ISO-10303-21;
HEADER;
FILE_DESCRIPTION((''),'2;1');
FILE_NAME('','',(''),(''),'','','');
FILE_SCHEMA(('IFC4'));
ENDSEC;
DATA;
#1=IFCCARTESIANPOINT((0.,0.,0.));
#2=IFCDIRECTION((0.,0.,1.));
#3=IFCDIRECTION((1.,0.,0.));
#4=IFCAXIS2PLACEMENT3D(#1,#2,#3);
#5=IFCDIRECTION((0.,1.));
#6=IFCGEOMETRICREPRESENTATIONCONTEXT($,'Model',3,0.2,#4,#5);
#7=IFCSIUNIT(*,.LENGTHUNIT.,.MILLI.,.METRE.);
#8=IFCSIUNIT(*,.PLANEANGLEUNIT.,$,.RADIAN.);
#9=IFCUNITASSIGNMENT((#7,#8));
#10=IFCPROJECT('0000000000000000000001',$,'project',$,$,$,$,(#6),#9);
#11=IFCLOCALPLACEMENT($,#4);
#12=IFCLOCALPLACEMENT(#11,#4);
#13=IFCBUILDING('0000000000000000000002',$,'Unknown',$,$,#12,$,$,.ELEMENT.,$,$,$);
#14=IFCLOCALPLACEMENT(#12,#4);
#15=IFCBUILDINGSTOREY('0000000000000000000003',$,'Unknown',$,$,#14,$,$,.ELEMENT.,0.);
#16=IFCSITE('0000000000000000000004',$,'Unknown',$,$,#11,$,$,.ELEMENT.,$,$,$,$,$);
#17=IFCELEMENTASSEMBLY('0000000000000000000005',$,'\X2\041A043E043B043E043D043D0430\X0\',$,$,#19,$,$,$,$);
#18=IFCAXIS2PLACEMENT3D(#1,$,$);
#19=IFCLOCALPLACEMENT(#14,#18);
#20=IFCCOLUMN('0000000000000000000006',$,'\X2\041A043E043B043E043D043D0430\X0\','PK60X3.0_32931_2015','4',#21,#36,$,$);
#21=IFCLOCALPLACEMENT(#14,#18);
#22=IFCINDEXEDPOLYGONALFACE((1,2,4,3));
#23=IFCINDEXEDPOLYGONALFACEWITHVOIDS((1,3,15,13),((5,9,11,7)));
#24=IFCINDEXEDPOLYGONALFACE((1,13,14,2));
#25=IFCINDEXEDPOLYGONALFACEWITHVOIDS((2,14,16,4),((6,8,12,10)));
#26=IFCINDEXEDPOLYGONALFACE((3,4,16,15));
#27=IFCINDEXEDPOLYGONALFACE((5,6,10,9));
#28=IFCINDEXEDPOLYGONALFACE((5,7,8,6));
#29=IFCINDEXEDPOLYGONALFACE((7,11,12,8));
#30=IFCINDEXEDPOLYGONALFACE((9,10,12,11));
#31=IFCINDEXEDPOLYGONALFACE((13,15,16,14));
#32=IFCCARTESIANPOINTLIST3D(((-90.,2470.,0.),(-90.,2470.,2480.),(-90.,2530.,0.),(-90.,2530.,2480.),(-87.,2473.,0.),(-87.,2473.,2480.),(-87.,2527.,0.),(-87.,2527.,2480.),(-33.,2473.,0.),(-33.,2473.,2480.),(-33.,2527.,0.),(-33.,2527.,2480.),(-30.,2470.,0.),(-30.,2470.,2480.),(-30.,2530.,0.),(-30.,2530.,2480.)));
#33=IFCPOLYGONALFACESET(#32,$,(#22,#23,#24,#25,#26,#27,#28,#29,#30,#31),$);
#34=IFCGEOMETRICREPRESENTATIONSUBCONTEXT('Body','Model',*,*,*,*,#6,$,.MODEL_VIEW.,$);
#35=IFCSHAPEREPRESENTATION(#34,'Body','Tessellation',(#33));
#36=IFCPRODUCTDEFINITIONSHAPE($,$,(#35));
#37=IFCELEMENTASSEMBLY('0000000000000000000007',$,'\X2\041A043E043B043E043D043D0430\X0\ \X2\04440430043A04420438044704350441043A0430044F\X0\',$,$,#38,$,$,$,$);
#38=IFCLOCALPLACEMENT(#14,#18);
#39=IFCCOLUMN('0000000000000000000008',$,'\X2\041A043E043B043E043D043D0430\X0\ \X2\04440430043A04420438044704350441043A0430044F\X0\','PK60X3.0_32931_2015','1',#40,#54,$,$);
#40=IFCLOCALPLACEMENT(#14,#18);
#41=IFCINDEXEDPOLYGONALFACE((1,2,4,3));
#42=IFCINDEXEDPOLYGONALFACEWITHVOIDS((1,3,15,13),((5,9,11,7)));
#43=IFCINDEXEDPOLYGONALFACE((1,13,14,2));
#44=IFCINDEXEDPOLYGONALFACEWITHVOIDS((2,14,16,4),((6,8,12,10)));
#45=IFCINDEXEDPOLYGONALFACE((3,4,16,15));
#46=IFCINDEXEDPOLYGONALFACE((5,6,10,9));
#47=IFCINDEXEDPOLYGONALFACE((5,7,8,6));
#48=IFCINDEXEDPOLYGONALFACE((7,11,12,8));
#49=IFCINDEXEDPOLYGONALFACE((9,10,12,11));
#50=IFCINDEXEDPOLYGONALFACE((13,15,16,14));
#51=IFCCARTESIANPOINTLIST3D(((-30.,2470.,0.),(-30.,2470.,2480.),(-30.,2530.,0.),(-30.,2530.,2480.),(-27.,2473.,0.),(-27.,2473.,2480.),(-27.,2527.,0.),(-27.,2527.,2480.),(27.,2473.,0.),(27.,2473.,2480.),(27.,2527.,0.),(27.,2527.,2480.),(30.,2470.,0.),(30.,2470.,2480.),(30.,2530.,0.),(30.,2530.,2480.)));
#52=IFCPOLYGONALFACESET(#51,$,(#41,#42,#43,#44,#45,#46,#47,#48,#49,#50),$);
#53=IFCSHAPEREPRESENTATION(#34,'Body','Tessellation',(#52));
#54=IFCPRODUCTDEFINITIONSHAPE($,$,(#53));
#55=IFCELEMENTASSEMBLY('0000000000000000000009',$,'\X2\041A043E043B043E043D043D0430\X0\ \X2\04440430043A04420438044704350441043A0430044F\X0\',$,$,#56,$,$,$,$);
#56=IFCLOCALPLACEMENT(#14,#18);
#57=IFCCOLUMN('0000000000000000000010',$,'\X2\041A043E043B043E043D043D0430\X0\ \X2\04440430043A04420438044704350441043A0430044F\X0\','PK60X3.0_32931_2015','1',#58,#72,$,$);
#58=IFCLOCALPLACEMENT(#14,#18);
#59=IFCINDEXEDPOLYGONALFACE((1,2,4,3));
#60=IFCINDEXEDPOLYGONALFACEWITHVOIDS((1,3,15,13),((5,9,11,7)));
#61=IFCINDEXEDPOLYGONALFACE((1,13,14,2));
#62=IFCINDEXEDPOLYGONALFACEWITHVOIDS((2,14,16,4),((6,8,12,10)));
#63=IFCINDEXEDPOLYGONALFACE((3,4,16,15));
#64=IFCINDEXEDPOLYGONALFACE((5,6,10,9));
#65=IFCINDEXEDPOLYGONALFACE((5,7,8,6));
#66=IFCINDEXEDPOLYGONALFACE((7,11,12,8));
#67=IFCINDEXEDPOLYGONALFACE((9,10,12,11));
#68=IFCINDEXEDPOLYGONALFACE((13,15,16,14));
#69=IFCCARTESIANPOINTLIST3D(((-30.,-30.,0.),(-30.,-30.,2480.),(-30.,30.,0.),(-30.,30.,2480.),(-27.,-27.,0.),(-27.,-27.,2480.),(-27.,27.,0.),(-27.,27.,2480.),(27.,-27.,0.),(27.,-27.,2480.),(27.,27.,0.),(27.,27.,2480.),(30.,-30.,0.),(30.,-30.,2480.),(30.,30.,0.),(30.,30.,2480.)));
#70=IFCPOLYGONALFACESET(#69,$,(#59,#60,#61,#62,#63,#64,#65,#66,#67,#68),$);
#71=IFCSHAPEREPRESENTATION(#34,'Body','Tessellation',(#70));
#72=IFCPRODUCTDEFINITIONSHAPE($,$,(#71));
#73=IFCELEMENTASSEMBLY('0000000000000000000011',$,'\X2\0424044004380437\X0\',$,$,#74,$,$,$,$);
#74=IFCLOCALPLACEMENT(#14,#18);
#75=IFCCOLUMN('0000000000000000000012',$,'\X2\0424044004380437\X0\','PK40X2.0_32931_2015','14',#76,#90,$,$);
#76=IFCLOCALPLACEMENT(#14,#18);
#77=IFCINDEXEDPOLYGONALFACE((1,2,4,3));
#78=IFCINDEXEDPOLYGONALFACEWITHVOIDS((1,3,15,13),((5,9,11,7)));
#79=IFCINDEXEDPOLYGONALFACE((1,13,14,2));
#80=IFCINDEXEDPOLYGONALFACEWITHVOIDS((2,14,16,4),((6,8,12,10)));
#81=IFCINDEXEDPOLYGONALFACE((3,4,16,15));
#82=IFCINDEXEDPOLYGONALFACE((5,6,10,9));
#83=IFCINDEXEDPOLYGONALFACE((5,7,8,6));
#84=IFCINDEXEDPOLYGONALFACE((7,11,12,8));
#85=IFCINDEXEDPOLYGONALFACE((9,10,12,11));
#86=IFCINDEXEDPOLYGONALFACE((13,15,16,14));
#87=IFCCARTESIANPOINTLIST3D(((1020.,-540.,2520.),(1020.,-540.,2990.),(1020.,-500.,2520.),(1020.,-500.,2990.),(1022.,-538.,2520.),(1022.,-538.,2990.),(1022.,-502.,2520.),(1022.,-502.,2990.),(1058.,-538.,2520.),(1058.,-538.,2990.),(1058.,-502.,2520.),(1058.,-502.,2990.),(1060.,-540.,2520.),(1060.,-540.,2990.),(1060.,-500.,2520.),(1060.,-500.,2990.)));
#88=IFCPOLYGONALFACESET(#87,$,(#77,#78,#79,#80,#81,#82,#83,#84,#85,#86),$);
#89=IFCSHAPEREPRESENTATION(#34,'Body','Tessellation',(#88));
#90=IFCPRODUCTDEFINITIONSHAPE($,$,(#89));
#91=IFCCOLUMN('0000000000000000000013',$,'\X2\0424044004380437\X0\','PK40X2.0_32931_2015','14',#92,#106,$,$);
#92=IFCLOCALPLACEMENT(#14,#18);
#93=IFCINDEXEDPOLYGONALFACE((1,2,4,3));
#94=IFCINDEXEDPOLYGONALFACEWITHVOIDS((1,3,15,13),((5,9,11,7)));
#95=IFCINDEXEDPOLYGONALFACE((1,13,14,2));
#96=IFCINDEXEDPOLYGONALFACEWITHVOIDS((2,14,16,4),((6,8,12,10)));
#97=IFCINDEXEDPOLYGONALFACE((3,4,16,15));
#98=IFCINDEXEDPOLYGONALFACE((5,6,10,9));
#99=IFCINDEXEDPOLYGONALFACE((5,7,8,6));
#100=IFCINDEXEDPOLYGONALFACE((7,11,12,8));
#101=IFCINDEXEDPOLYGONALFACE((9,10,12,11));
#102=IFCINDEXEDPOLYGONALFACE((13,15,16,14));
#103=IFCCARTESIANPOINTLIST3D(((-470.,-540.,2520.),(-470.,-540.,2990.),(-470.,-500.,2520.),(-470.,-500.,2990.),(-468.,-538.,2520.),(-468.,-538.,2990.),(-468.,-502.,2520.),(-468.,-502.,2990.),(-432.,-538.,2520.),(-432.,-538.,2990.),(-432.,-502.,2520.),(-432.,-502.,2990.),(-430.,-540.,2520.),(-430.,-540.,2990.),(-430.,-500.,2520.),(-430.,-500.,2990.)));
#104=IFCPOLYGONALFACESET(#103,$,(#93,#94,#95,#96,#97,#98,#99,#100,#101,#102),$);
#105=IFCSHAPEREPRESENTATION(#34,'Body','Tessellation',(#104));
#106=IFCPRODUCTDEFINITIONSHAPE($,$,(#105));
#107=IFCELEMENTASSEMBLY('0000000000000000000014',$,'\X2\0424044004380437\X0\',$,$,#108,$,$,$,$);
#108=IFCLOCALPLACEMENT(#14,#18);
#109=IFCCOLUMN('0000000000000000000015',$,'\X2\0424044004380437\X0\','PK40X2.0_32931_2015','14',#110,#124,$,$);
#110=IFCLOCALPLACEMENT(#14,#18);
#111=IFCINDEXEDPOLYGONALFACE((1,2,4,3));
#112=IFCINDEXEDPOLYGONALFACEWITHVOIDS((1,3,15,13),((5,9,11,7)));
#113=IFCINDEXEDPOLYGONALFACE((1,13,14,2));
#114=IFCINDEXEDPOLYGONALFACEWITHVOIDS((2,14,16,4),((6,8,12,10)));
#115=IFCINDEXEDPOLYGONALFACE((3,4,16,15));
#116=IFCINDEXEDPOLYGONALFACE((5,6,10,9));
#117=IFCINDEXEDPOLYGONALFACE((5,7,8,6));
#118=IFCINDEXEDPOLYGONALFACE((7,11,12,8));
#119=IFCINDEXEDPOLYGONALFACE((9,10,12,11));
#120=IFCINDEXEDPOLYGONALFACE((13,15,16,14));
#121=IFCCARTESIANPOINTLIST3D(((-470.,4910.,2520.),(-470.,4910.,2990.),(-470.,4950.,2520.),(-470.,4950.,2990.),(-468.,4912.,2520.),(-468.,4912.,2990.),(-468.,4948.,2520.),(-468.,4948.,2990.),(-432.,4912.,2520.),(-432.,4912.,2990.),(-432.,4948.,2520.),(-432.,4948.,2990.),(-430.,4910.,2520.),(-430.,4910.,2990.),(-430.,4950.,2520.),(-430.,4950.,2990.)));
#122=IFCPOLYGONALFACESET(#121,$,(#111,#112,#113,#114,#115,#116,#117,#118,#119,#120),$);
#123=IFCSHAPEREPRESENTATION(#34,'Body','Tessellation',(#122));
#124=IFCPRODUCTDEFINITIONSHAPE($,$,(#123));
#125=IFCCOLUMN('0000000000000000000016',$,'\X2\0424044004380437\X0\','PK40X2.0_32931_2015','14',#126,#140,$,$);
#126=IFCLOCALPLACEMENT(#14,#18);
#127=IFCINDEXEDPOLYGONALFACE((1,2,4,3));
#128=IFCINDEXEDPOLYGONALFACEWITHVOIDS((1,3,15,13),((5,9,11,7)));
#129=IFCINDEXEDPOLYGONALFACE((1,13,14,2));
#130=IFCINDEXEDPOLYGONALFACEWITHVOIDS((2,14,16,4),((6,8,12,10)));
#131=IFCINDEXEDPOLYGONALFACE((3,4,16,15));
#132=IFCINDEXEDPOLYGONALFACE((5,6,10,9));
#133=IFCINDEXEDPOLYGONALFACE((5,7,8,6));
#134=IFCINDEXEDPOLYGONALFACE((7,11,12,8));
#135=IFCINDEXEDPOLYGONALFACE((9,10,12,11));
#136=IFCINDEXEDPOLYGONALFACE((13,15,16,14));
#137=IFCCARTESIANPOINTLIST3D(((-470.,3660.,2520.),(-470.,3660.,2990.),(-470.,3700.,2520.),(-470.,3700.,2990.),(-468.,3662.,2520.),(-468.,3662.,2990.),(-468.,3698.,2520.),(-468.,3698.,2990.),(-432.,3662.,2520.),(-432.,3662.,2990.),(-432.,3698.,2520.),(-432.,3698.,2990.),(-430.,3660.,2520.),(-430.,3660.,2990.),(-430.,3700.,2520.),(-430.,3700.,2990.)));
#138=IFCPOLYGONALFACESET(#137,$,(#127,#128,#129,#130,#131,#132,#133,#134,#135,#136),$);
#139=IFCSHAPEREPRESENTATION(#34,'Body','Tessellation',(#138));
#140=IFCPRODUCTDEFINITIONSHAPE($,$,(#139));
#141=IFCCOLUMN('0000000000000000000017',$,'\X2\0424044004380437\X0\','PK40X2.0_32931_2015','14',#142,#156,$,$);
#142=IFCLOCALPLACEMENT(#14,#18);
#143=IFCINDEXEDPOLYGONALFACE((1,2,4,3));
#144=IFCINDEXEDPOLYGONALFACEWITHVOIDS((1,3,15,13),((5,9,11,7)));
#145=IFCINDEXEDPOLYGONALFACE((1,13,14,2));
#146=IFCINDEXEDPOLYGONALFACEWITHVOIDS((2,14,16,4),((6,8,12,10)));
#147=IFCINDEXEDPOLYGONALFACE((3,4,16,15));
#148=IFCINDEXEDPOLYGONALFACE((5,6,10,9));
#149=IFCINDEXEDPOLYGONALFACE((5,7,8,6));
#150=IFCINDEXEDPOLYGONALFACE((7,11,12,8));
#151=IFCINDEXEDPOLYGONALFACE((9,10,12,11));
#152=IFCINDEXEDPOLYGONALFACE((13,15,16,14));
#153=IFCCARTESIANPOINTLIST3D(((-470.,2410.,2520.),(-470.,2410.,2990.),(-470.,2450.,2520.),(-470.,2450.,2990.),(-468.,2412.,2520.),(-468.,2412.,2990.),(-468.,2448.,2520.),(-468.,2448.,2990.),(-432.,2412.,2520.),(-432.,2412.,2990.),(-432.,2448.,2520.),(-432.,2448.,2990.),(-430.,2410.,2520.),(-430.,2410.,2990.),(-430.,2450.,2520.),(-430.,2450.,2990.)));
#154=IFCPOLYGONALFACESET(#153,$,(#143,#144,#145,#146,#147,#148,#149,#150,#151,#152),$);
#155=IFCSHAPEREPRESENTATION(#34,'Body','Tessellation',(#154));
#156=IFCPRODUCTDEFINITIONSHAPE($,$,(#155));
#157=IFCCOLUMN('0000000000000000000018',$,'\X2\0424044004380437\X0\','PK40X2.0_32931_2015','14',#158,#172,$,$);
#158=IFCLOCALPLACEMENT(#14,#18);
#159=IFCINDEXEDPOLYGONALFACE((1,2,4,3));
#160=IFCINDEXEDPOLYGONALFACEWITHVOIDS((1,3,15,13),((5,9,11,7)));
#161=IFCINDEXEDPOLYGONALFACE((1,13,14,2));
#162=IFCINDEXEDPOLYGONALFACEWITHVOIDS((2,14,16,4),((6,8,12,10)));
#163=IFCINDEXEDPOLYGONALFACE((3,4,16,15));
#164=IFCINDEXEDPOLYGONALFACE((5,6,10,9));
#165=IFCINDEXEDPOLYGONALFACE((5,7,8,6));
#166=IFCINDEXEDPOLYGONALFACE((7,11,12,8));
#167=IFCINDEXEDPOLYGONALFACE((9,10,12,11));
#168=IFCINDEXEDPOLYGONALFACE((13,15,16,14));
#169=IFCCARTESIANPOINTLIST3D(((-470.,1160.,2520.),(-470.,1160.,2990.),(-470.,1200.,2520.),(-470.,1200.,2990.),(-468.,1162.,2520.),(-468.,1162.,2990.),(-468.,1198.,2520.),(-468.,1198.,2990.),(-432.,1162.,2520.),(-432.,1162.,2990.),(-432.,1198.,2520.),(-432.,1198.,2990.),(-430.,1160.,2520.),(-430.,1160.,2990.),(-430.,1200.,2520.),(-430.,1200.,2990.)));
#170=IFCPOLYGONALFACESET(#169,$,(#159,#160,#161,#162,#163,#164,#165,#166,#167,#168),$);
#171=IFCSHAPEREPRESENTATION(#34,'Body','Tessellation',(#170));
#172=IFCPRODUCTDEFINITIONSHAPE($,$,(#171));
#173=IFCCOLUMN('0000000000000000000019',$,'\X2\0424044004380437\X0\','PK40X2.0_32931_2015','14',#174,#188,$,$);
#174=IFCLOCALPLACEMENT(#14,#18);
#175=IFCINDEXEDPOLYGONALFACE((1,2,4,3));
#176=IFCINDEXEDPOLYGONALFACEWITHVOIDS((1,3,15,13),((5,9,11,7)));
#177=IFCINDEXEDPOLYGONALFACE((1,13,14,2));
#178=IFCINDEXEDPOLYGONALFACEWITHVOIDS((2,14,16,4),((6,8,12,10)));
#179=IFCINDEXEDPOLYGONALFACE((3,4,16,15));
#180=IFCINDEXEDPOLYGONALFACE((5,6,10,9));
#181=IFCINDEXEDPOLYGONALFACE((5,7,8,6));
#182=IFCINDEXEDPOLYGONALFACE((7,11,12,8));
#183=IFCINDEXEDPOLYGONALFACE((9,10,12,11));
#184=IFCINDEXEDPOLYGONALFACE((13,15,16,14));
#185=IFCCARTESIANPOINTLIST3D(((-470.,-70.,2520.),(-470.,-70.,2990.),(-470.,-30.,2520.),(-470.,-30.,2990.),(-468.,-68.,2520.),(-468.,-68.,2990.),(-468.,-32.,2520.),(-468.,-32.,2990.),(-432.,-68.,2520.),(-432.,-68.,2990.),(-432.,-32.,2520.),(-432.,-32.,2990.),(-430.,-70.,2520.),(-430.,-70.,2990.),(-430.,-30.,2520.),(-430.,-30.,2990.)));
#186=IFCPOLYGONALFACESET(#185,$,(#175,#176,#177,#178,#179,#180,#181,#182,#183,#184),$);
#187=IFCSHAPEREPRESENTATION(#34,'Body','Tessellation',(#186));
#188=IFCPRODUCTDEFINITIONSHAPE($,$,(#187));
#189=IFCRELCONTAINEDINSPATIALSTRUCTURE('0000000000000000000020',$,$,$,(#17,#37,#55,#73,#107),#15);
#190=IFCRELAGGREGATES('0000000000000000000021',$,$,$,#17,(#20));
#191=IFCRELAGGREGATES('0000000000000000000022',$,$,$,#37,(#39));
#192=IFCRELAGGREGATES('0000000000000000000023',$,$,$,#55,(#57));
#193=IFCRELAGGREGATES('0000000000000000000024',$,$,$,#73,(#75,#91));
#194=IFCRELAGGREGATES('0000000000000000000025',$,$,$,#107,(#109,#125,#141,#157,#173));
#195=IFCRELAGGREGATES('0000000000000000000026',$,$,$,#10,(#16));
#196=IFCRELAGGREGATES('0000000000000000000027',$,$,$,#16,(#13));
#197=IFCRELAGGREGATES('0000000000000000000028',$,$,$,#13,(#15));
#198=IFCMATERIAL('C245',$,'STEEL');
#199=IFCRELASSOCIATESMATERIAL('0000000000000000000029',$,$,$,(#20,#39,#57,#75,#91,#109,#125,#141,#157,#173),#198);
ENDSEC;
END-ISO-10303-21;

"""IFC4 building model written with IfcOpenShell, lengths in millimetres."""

from ifc_helpers import new_model, si_unit, direction, frame, origin_with_axes, place, context, subcontext, project, spatial, line, indexed_curve, outline, extrude, material, element, aggregate, save


model = new_model("IFC4")

# Units and contexts
model_context = context("Model", 3, precision=0.2, world=origin_with_axes(), true_north=direction((0.0, 1.0)))
body_context = subcontext(model_context, "Body", "Model", "MODEL_VIEW")
ifc_project = project(units=[si_unit("LENGTHUNIT", "METRE", prefix="MILLI"), si_unit("PLANEANGLEUNIT", "RADIAN")], contexts=[model_context])

# Site, building, storey
site_placement = place(None, origin_with_axes())
site = spatial("IfcSite", under=ifc_project, at=site_placement, Name="Unknown", CompositionType="ELEMENT")
building_placement = place(site_placement, origin_with_axes())
building = spatial("IfcBuilding", under=site, at=building_placement, Name="Unknown", CompositionType="ELEMENT")
storey_placement = place(building_placement, origin_with_axes())
storey = spatial("IfcBuildingStorey", under=building, at=storey_placement, Name="Unknown", CompositionType="ELEMENT", Elevation=0.0)

# Element assemblies, columns
assembly_1_placement = place(storey_placement, frame((-60.0, 2500.0, 0.0), z_axis=(-1.0, 0.0, 0.0), x_axis=(0.0, 0.0, 1.0)))
assembly_1 = element("IfcElementAssembly", 1, at=assembly_1_placement, inside=storey, Name="Колонна")
ifc_material = material(Name="C245", Category="STEEL")
column_1_placement = place(assembly_1_placement, origin_with_axes())
column_1 = element("IfcColumn", 2, at=column_1_placement, material=ifc_material, Name="Колонна", Description="PK60X3.0_32931_2015", ObjectType="4", context=body_context, shape_type="SolidModel", body=[
    extrude(outline(indexed_curve([(-30.0, -30.0), (30.0, -30.0), (30.0, 30.0), (-30.0, 30.0)], segments=[line(1, 2, 3, 4, 1)]), holes=[indexed_curve([(-27.0, -27.0), (-27.0, 27.0), (27.0, 27.0), (27.0, -27.0)], segments=[line(1, 2, 3, 4, 1)])]), frame((0.0, 0.0, 0.0), z_axis=(-1.0, 0.0, 0.0), x_axis=(0.0, 0.0, 1.0)), (0.0, 0.0, -1.0), 2480.0),
])
aggregate(assembly_1, [column_1])
assembly_2_placement = place(storey_placement, frame((0.0, 2500.0, 0.0), z_axis=(-1.0, 0.0, 0.0), x_axis=(0.0, 0.0, 1.0)))
assembly_2 = element("IfcElementAssembly", 3, at=assembly_2_placement, inside=storey, Name="Колонна фактическая")
column_2_placement = place(assembly_2_placement, origin_with_axes())
column_2 = element("IfcColumn", 4, at=column_2_placement, material=ifc_material, Name="Колонна фактическая", Description="PK60X3.0_32931_2015", ObjectType="1", context=body_context, shape_type="SolidModel", body=[
    extrude(outline(indexed_curve([(-30.0, -30.0), (30.0, -30.0), (30.0, 30.0), (-30.0, 30.0)], segments=[line(1, 2, 3, 4, 1)]), holes=[indexed_curve([(-27.0, -27.0), (-27.0, 27.0), (27.0, 27.0), (27.0, -27.0)], segments=[line(1, 2, 3, 4, 1)])]), frame((0.0, 0.0, 0.0), z_axis=(-1.0, 0.0, 0.0), x_axis=(0.0, 0.0, 1.0)), (0.0, 0.0, -1.0), 2480.0),
])
aggregate(assembly_2, [column_2])
assembly_3_placement = place(storey_placement, frame((0.0, 0.0, 0.0), z_axis=(-1.0, 0.0, 0.0), x_axis=(0.0, 0.0, 1.0)))
assembly_3 = element("IfcElementAssembly", 5, at=assembly_3_placement, inside=storey, Name="Колонна фактическая")
column_3_placement = place(assembly_3_placement, origin_with_axes())
column_3 = element("IfcColumn", 6, at=column_3_placement, material=ifc_material, Name="Колонна фактическая", Description="PK60X3.0_32931_2015", ObjectType="1", context=body_context, shape_type="SolidModel", body=[
    extrude(outline(indexed_curve([(-30.0, -30.0), (30.0, -30.0), (30.0, 30.0), (-30.0, 30.0)], segments=[line(1, 2, 3, 4, 1)]), holes=[indexed_curve([(-27.0, -27.0), (-27.0, 27.0), (27.0, 27.0), (27.0, -27.0)], segments=[line(1, 2, 3, 4, 1)])]), frame((0.0, 0.0, 0.0), z_axis=(-1.0, 0.0, 0.0), x_axis=(0.0, 0.0, 1.0)), (0.0, 0.0, -1.0), 2480.0),
])
aggregate(assembly_3, [column_3])

# Element assemblies, columns
assembly_4_placement = place(storey_placement, frame((-470.0, -520.0, 3010.0), z_axis=(0.0, -1.0, 0.0), x_axis=(1.0, 0.0, 0.0)))
assembly_4 = element("IfcElementAssembly", 7, at=assembly_4_placement, inside=storey, Name="Фриз")
column_4_placement = place(assembly_4_placement, frame((1510.0, -490.0, 0.0), z_axis=(0.0, 0.0, -1.0), x_axis=(0.0, 1.0, 0.0)))
column_4 = element("IfcColumn", 8, at=column_4_placement, material=ifc_material, Name="Фриз", Description="PK40X2.0_32931_2015", ObjectType="14", context=body_context, shape_type="SolidModel", body=[
    extrude(outline(indexed_curve([(-20.0, -20.0), (20.0, -20.0), (20.0, 20.0), (-20.0, 20.0)], segments=[line(1, 2, 3, 4, 1)]), holes=[indexed_curve([(-18.0, -18.0), (-18.0, 18.0), (18.0, 18.0), (18.0, -18.0)], segments=[line(1, 2, 3, 4, 1)])]), frame((0.0, 0.0, 0.0), z_axis=(-1.0, 0.0, 0.0), x_axis=(0.0, 0.0, 1.0)), (0.0, 0.0, -1.0), 470.0),
])
column_5_placement = place(assembly_4_placement, frame((20.0, -490.0, 0.0), z_axis=(0.0, 0.0, -1.0), x_axis=(0.0, 1.0, 0.0)))
column_5 = element("IfcColumn", 9, at=column_5_placement, material=ifc_material, Name="Фриз", Description="PK40X2.0_32931_2015", ObjectType="14", context=body_context, shape_type="SolidModel", body=[
    extrude(outline(indexed_curve([(-20.0, -20.0), (20.0, -20.0), (20.0, 20.0), (-20.0, 20.0)], segments=[line(1, 2, 3, 4, 1)]), holes=[indexed_curve([(-18.0, -18.0), (-18.0, 18.0), (18.0, 18.0), (18.0, -18.0)], segments=[line(1, 2, 3, 4, 1)])]), frame((0.0, 0.0, 0.0), z_axis=(-1.0, 0.0, 0.0), x_axis=(0.0, 0.0, 1.0)), (0.0, 0.0, -1.0), 470.0),
])
assembly_5_placement = place(storey_placement, frame((-450.0, -500.0, 3010.0), z_axis=(1.0, 0.0, 0.0), x_axis=(0.0, 1.0, 0.0)))
assembly_5 = element("IfcElementAssembly", 10, at=assembly_5_placement, inside=storey, Name="Фриз")
column_6_placement = place(assembly_5_placement, frame((5430.0, -490.0, 0.0), z_axis=(1.0, 0.0, 0.0), x_axis=(0.0, 1.0, 0.0)))
column_6 = element("IfcColumn", 11, at=column_6_placement, material=ifc_material, Name="Фриз", Description="PK40X2.0_32931_2015", ObjectType="14", context=body_context, shape_type="SolidModel", body=[
    extrude(outline(indexed_curve([(-20.0, -20.0), (20.0, -20.0), (20.0, 20.0), (-20.0, 20.0)], segments=[line(1, 2, 3, 4, 1)]), holes=[indexed_curve([(-18.0, -18.0), (-18.0, 18.0), (18.0, 18.0), (18.0, -18.0)], segments=[line(1, 2, 3, 4, 1)])]), frame((0.0, 0.0, 0.0), z_axis=(-1.0, 0.0, 0.0), x_axis=(0.0, 0.0, 1.0)), (0.0, 0.0, -1.0), 470.0),
])
column_7_placement = place(assembly_5_placement, frame((4180.0, -490.0, 0.0), z_axis=(1.0, 0.0, 0.0), x_axis=(0.0, 1.0, 0.0)))
column_7 = element("IfcColumn", 12, at=column_7_placement, material=ifc_material, Name="Фриз", Description="PK40X2.0_32931_2015", ObjectType="14", context=body_context, shape_type="SolidModel", body=[
    extrude(outline(indexed_curve([(-20.0, -20.0), (20.0, -20.0), (20.0, 20.0), (-20.0, 20.0)], segments=[line(1, 2, 3, 4, 1)]), holes=[indexed_curve([(-18.0, -18.0), (-18.0, 18.0), (18.0, 18.0), (18.0, -18.0)], segments=[line(1, 2, 3, 4, 1)])]), frame((0.0, 0.0, 0.0), z_axis=(-1.0, 0.0, 0.0), x_axis=(0.0, 0.0, 1.0)), (0.0, 0.0, -1.0), 470.0),
])
column_8_placement = place(assembly_5_placement, frame((2930.0, -490.0, 0.0), z_axis=(1.0, 0.0, 0.0), x_axis=(0.0, 1.0, 0.0)))
column_8 = element("IfcColumn", 13, at=column_8_placement, material=ifc_material, Name="Фриз", Description="PK40X2.0_32931_2015", ObjectType="14", context=body_context, shape_type="SolidModel", body=[
    extrude(outline(indexed_curve([(-20.0, -20.0), (20.0, -20.0), (20.0, 20.0), (-20.0, 20.0)], segments=[line(1, 2, 3, 4, 1)]), holes=[indexed_curve([(-18.0, -18.0), (-18.0, 18.0), (18.0, 18.0), (18.0, -18.0)], segments=[line(1, 2, 3, 4, 1)])]), frame((0.0, 0.0, 0.0), z_axis=(-1.0, 0.0, 0.0), x_axis=(0.0, 0.0, 1.0)), (0.0, 0.0, -1.0), 470.0),
])
column_9_placement = place(assembly_5_placement, frame((1680.0, -490.0, 0.0), z_axis=(1.0, 0.0, 0.0), x_axis=(0.0, 1.0, 0.0)))
column_9 = element("IfcColumn", 14, at=column_9_placement, material=ifc_material, Name="Фриз", Description="PK40X2.0_32931_2015", ObjectType="14", context=body_context, shape_type="SolidModel", body=[
    extrude(outline(indexed_curve([(-20.0, -20.0), (20.0, -20.0), (20.0, 20.0), (-20.0, 20.0)], segments=[line(1, 2, 3, 4, 1)]), holes=[indexed_curve([(-18.0, -18.0), (-18.0, 18.0), (18.0, 18.0), (18.0, -18.0)], segments=[line(1, 2, 3, 4, 1)])]), frame((0.0, 0.0, 0.0), z_axis=(-1.0, 0.0, 0.0), x_axis=(0.0, 0.0, 1.0)), (0.0, 0.0, -1.0), 470.0),
])
column_10_placement = place(assembly_5_placement, frame((450.0, -490.0, 0.0), z_axis=(1.0, 0.0, 0.0), x_axis=(0.0, 1.0, 0.0)))
column_10 = element("IfcColumn", 15, at=column_10_placement, material=ifc_material, Name="Фриз", Description="PK40X2.0_32931_2015", ObjectType="14", context=body_context, shape_type="SolidModel", body=[
    extrude(outline(indexed_curve([(-20.0, -20.0), (20.0, -20.0), (20.0, 20.0), (-20.0, 20.0)], segments=[line(1, 2, 3, 4, 1)]), holes=[indexed_curve([(-18.0, -18.0), (-18.0, 18.0), (18.0, 18.0), (18.0, -18.0)], segments=[line(1, 2, 3, 4, 1)])]), frame((0.0, 0.0, 0.0), z_axis=(-1.0, 0.0, 0.0), x_axis=(0.0, 0.0, 1.0)), (0.0, 0.0, -1.0), 470.0),
])

aggregate(assembly_4, [column_4, column_5])
aggregate(assembly_5, [column_6, column_7, column_8, column_9, column_10])

save(model, "model.ifc")
